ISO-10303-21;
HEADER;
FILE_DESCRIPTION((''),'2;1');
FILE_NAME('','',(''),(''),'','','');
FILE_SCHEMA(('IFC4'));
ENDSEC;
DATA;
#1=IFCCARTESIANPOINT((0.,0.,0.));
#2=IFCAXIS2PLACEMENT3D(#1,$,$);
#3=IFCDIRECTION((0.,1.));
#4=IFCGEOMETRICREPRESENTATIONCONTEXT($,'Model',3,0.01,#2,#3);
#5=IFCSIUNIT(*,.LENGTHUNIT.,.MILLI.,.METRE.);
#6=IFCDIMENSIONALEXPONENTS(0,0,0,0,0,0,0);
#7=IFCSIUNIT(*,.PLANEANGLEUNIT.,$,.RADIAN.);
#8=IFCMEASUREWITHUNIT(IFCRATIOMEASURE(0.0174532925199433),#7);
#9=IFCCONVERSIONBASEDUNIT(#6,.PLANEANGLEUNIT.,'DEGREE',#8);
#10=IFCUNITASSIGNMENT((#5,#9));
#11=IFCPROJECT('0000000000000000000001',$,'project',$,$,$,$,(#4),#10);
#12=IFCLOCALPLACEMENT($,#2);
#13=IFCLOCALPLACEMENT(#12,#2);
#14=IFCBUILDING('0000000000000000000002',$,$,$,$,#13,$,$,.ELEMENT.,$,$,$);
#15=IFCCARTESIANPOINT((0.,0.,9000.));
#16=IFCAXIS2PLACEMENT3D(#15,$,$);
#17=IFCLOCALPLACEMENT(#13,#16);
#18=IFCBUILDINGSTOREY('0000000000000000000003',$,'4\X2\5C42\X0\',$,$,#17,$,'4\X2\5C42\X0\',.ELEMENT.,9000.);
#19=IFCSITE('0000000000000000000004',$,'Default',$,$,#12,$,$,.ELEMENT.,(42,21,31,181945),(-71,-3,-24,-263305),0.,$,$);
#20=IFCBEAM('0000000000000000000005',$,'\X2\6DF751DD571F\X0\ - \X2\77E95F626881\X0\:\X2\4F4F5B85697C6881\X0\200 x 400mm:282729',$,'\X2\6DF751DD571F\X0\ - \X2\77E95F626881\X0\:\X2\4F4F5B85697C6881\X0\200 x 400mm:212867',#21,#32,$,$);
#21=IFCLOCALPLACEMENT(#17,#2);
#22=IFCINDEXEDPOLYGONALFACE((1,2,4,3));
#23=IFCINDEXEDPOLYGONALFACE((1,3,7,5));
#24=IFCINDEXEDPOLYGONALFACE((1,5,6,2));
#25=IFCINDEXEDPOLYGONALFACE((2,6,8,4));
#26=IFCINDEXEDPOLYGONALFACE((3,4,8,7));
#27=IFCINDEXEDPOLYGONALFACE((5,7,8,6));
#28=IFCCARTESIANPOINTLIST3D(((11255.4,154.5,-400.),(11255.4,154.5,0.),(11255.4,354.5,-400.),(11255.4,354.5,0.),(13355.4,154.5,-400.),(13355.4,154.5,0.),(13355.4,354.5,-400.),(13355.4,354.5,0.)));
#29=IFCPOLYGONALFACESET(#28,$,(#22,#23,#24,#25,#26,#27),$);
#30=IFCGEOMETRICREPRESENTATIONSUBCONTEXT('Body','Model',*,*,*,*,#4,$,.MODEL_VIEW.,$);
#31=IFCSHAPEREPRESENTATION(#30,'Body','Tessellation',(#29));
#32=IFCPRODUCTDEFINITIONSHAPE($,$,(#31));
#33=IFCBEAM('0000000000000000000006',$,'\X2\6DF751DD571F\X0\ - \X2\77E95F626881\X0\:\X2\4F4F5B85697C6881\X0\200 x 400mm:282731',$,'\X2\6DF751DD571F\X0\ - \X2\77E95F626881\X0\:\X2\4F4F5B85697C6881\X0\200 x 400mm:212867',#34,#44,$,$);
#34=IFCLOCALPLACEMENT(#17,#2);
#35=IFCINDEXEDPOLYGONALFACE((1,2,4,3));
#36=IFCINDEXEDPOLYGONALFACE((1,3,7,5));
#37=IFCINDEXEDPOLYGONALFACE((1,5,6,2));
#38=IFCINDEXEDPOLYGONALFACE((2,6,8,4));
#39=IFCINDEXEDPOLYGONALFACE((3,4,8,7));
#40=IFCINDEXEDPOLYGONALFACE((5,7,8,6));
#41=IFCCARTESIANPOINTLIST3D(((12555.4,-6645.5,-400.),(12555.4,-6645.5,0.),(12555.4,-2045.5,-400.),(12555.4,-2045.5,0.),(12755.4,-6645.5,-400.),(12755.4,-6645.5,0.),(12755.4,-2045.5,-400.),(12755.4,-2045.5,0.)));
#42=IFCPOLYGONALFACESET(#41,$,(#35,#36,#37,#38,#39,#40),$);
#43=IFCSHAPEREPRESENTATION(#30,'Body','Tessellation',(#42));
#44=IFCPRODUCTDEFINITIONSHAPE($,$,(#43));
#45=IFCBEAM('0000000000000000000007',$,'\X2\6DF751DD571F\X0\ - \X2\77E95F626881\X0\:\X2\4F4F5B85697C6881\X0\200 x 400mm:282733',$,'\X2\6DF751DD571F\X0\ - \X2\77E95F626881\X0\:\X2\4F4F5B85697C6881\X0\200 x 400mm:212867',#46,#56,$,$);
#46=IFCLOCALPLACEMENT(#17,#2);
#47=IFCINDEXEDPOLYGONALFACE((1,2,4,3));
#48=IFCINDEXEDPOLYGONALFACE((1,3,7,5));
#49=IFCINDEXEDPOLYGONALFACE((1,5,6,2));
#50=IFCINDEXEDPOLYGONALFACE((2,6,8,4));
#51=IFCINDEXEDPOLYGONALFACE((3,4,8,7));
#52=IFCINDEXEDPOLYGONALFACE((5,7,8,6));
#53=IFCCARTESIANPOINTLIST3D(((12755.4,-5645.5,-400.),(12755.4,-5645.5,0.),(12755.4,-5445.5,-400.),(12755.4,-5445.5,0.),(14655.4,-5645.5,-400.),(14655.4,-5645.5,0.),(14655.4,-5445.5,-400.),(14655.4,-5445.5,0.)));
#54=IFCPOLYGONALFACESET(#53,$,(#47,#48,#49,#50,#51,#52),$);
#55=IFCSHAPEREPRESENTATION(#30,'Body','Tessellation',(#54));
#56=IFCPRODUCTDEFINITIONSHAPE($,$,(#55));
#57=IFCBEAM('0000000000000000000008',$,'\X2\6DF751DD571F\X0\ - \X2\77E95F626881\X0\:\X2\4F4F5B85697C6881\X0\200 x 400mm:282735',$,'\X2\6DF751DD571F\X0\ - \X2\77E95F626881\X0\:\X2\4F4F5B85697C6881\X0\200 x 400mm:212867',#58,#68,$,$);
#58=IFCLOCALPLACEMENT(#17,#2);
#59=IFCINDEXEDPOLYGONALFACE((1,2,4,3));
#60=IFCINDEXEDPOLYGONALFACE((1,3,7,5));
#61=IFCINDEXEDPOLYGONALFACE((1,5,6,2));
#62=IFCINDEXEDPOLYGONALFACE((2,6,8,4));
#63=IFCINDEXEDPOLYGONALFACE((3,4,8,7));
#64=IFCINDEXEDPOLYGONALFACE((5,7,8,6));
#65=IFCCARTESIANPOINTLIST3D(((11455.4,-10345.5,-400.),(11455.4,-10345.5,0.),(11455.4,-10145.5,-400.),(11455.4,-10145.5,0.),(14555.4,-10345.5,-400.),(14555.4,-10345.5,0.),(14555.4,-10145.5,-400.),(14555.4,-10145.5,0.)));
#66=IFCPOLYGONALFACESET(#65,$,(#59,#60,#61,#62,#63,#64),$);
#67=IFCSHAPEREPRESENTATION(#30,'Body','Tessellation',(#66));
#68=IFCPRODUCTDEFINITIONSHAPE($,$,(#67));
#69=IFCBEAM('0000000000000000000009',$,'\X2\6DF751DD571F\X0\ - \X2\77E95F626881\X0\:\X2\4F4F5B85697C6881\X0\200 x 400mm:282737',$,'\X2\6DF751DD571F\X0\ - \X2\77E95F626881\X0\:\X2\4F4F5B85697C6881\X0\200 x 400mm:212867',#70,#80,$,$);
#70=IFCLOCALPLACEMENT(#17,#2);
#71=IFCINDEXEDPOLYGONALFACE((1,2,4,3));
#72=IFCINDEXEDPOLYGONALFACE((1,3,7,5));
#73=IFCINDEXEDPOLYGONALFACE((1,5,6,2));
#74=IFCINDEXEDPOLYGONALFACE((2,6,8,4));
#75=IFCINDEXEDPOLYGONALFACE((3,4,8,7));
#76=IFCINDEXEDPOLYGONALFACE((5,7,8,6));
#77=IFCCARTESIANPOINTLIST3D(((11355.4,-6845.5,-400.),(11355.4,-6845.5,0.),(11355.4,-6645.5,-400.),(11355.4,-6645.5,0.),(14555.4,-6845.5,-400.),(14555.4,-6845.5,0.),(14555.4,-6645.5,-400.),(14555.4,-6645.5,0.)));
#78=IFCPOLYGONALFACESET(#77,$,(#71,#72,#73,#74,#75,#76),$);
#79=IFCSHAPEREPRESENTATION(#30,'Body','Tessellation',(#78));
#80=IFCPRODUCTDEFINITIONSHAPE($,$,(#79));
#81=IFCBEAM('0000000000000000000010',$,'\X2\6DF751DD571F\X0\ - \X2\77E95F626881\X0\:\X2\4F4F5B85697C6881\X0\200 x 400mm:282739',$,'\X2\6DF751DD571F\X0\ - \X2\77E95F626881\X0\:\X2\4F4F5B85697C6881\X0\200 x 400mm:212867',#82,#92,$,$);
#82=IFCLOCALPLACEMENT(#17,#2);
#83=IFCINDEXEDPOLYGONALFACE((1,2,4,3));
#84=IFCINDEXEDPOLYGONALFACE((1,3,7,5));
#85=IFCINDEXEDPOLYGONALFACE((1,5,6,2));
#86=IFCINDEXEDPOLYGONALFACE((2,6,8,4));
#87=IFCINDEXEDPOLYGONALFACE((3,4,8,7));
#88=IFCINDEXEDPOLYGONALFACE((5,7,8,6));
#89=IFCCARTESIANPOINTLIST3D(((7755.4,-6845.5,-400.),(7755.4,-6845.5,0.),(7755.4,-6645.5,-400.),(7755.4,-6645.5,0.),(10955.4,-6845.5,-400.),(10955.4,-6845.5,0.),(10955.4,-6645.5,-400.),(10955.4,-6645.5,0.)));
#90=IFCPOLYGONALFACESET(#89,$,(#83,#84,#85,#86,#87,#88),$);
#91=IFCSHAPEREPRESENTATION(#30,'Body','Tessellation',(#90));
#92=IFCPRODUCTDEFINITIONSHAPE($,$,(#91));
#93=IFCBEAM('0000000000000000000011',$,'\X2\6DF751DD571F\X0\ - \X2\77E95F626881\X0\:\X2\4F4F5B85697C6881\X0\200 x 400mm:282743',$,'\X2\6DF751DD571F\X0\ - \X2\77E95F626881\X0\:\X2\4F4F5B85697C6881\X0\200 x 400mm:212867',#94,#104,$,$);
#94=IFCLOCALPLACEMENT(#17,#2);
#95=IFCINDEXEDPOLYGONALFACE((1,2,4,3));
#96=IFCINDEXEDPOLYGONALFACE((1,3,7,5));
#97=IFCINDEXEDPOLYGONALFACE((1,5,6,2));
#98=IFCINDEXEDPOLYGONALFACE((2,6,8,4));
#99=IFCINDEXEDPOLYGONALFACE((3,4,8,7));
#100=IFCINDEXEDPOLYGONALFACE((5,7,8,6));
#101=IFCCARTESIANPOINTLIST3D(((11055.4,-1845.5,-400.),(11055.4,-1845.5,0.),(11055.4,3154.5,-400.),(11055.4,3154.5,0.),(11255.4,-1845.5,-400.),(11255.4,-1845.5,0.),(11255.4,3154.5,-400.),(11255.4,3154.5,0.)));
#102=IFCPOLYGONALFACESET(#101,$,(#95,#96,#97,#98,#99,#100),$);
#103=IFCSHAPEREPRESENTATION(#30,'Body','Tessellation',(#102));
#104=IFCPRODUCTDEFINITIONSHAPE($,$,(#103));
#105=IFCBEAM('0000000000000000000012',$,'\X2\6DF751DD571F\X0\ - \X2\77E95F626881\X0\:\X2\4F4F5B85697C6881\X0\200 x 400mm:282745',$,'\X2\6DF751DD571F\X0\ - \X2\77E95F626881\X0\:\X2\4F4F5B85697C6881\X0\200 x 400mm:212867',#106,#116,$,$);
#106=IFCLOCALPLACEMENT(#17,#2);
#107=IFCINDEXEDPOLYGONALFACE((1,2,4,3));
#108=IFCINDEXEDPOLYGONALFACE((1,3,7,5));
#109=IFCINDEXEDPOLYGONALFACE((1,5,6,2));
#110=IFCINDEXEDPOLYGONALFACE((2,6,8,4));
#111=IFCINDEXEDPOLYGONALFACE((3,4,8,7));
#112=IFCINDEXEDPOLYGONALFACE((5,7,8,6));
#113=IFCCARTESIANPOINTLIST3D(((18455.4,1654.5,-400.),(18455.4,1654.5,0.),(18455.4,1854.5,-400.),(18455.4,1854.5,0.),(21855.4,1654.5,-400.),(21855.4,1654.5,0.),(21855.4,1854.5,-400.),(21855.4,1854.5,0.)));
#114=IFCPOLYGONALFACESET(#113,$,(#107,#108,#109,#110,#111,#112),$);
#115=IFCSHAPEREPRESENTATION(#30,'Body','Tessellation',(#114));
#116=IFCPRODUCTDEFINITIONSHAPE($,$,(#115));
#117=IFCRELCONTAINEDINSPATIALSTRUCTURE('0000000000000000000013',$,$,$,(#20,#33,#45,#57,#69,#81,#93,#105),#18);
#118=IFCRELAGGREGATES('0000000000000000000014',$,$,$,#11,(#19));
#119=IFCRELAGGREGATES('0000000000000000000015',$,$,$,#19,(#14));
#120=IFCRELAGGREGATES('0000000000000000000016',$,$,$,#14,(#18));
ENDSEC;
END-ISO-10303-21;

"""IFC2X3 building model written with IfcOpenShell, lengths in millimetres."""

from ifc_helpers import new_model, entity, si_unit, converted_unit, direction, frame, frame_2d, origin, origin_2d_with_axis, place, context, subcontext, project, spatial, rectangle, extrude, element, save


model = new_model("IFC2X3")

# Units and contexts
model_context = context("Model", 3, precision=0.01, world=origin(), true_north=direction((0.0, 1.0)))
body_context = subcontext(model_context, "Body", "Model", "MODEL_VIEW")
ifc_project = project(units=[si_unit("LENGTHUNIT", "METRE", prefix="MILLI"), converted_unit("PLANEANGLEUNIT", "DEGREE", entity("IfcRatioMeasure", 0.0174532925199433), si_unit("PLANEANGLEUNIT", "RADIAN"), dimensions=[0, 0, 0, 0, 0, 0, 0])], contexts=[model_context])

# Site, building, storey
site_placement = place(None, origin())
site = spatial("IfcSite", under=ifc_project, at=site_placement, Name="Default", CompositionType="ELEMENT", RefLatitude=(42, 21, 31, 181945), RefLongitude=(-71, -3, -24, -263305), RefElevation=0.0)
building_placement = place(site_placement, origin())
building = spatial("IfcBuilding", under=site, at=building_placement, CompositionType="ELEMENT")
storey_placement = place(building_placement, frame((0.0, 0.0, 9000.0)))
storey = spatial("IfcBuildingStorey", under=building, at=storey_placement, Name="4层", LongName="4层", CompositionType="ELEMENT", Elevation=9000.0)

# Beams
beam_1_placement = place(storey_placement, frame((11155.4, 254.5, 0.0)))
element("IfcBeam", 1, at=beam_1_placement, inside=storey, Name="混凝土 - 矩形梁:住宅楼梁200 x 400mm:282729", ObjectType="混凝土 - 矩形梁:住宅楼梁200 x 400mm:212867", context=body_context, shape_type="SweptSolid", body=[
    extrude(rectangle(XDim=400.0, YDim=200.0, at=frame_2d((0.0, 0.0), x_axis=(1.0, 0.0))), frame((100.0, 0.0, -200.0), z_axis=(1.0, 0.0, 0.0), x_axis=(0.0, 0.0, -1.0)), (0.0, 0.0, 1.0), 2100.0),
])
beam_2_placement = place(storey_placement, frame((12655.4, -1945.5, 0.0), z_axis=(0.0, 0.0, 1.0), x_axis=(0.0, -1.0, 0.0)))
element("IfcBeam", 2, at=beam_2_placement, inside=storey, Name="混凝土 - 矩形梁:住宅楼梁200 x 400mm:282731", ObjectType="混凝土 - 矩形梁:住宅楼梁200 x 400mm:212867", context=body_context, shape_type="SweptSolid", body=[
    extrude(rectangle(XDim=400.0, YDim=200.0, at=origin_2d_with_axis()), frame((100.0, 0.0, -200.0), z_axis=(1.0, 0.0, 0.0), x_axis=(0.0, 0.0, -1.0)), (0.0, 0.0, 1.0), 4600.0),
])
beam_3_placement = place(storey_placement, frame((12655.4, -5545.5, 0.0)))
element("IfcBeam", 3, at=beam_3_placement, inside=storey, Name="混凝土 - 矩形梁:住宅楼梁200 x 400mm:282733", ObjectType="混凝土 - 矩形梁:住宅楼梁200 x 400mm:212867", context=body_context, shape_type="SweptSolid", body=[
    extrude(rectangle(XDim=400.0, YDim=200.0, at=frame_2d((0.0, 0.0), x_axis=(1.0, 0.0))), frame((100.0, 0.0, -200.0), z_axis=(1.0, 0.0, 0.0), x_axis=(0.0, 0.0, -1.0)), (0.0, 0.0, 1.0), 1900.0),
])
beam_4_placement = place(storey_placement, frame((11455.4, -10245.5, 0.0)))
element("IfcBeam", 4, at=beam_4_placement, inside=storey, Name="混凝土 - 矩形梁:住宅楼梁200 x 400mm:282735", ObjectType="混凝土 - 矩形梁:住宅楼梁200 x 400mm:212867", context=body_context, shape_type="SweptSolid", body=[
    extrude(rectangle(XDim=400.0, YDim=200.0, at=frame_2d((0.0, 0.0), x_axis=(1.0, 0.0))), frame((0.0, 0.0, -200.0), z_axis=(1.0, 0.0, 0.0), x_axis=(0.0, 0.0, -1.0)), (0.0, 0.0, 1.0), 3100.0),
])
beam_5_placement = place(storey_placement, frame((11155.4, -6745.5, 0.0)))
element("IfcBeam", 5, at=beam_5_placement, inside=storey, Name="混凝土 - 矩形梁:住宅楼梁200 x 400mm:282737", ObjectType="混凝土 - 矩形梁:住宅楼梁200 x 400mm:212867", context=body_context, shape_type="SweptSolid", body=[
    extrude(rectangle(XDim=400.0, YDim=200.0, at=frame_2d((0.0, 0.0), x_axis=(1.0, 0.0))), frame((200.0, 0.0, -200.0), z_axis=(1.0, 0.0, 0.0), x_axis=(0.0, 0.0, -1.0)), (0.0, 0.0, 1.0), 3200.0),
])
beam_6_placement = place(storey_placement, frame((11155.4, -6745.5, 0.0), z_axis=(0.0, 0.0, 1.0), x_axis=(-1.0, 0.0, 0.0)))
element("IfcBeam", 6, at=beam_6_placement, inside=storey, Name="混凝土 - 矩形梁:住宅楼梁200 x 400mm:282739", ObjectType="混凝土 - 矩形梁:住宅楼梁200 x 400mm:212867", context=body_context, shape_type="SweptSolid", body=[
    extrude(rectangle(XDim=400.0, YDim=200.0, at=frame_2d((0.0, 0.0), x_axis=(1.0, 0.0))), frame((200.0, 0.0, -200.0), z_axis=(1.0, 0.0, 0.0), x_axis=(0.0, 0.0, -1.0)), (0.0, 0.0, 1.0), 3200.0),
])
beam_7_placement = place(storey_placement, frame((11155.4, 3254.5, 0.0), z_axis=(0.0, 0.0, 1.0), x_axis=(0.0, -1.0, 0.0)))
element("IfcBeam", 7, at=beam_7_placement, inside=storey, Name="混凝土 - 矩形梁:住宅楼梁200 x 400mm:282743", ObjectType="混凝土 - 矩形梁:住宅楼梁200 x 400mm:212867", context=body_context, shape_type="SweptSolid", body=[
    extrude(rectangle(XDim=400.0, YDim=200.0, at=frame_2d((0.0, 0.0), x_axis=(1.0, 0.0))), frame((100.0, 0.0, -200.0), z_axis=(1.0, 0.0, 0.0), x_axis=(0.0, 0.0, -1.0)), (0.0, 0.0, 1.0), 5000.0),
])
beam_8_placement = place(storey_placement, frame((21955.4, 1754.5, 0.0), z_axis=(0.0, 0.0, 1.0), x_axis=(-1.0, 0.0, 0.0)))
element("IfcBeam", 8, at=beam_8_placement, inside=storey, Name="混凝土 - 矩形梁:住宅楼梁200 x 400mm:282745", ObjectType="混凝土 - 矩形梁:住宅楼梁200 x 400mm:212867", context=body_context, shape_type="SweptSolid", body=[
    extrude(rectangle(XDim=400.0, YDim=200.0, at=frame_2d((0.0, 0.0), x_axis=(1.0, 0.0))), frame((100.0, 0.0, -200.0), z_axis=(1.0, 0.0, 0.0), x_axis=(0.0, 0.0, -1.0)), (0.0, 0.0, 1.0), 3400.0),
])

save(model, "model.ifc")
